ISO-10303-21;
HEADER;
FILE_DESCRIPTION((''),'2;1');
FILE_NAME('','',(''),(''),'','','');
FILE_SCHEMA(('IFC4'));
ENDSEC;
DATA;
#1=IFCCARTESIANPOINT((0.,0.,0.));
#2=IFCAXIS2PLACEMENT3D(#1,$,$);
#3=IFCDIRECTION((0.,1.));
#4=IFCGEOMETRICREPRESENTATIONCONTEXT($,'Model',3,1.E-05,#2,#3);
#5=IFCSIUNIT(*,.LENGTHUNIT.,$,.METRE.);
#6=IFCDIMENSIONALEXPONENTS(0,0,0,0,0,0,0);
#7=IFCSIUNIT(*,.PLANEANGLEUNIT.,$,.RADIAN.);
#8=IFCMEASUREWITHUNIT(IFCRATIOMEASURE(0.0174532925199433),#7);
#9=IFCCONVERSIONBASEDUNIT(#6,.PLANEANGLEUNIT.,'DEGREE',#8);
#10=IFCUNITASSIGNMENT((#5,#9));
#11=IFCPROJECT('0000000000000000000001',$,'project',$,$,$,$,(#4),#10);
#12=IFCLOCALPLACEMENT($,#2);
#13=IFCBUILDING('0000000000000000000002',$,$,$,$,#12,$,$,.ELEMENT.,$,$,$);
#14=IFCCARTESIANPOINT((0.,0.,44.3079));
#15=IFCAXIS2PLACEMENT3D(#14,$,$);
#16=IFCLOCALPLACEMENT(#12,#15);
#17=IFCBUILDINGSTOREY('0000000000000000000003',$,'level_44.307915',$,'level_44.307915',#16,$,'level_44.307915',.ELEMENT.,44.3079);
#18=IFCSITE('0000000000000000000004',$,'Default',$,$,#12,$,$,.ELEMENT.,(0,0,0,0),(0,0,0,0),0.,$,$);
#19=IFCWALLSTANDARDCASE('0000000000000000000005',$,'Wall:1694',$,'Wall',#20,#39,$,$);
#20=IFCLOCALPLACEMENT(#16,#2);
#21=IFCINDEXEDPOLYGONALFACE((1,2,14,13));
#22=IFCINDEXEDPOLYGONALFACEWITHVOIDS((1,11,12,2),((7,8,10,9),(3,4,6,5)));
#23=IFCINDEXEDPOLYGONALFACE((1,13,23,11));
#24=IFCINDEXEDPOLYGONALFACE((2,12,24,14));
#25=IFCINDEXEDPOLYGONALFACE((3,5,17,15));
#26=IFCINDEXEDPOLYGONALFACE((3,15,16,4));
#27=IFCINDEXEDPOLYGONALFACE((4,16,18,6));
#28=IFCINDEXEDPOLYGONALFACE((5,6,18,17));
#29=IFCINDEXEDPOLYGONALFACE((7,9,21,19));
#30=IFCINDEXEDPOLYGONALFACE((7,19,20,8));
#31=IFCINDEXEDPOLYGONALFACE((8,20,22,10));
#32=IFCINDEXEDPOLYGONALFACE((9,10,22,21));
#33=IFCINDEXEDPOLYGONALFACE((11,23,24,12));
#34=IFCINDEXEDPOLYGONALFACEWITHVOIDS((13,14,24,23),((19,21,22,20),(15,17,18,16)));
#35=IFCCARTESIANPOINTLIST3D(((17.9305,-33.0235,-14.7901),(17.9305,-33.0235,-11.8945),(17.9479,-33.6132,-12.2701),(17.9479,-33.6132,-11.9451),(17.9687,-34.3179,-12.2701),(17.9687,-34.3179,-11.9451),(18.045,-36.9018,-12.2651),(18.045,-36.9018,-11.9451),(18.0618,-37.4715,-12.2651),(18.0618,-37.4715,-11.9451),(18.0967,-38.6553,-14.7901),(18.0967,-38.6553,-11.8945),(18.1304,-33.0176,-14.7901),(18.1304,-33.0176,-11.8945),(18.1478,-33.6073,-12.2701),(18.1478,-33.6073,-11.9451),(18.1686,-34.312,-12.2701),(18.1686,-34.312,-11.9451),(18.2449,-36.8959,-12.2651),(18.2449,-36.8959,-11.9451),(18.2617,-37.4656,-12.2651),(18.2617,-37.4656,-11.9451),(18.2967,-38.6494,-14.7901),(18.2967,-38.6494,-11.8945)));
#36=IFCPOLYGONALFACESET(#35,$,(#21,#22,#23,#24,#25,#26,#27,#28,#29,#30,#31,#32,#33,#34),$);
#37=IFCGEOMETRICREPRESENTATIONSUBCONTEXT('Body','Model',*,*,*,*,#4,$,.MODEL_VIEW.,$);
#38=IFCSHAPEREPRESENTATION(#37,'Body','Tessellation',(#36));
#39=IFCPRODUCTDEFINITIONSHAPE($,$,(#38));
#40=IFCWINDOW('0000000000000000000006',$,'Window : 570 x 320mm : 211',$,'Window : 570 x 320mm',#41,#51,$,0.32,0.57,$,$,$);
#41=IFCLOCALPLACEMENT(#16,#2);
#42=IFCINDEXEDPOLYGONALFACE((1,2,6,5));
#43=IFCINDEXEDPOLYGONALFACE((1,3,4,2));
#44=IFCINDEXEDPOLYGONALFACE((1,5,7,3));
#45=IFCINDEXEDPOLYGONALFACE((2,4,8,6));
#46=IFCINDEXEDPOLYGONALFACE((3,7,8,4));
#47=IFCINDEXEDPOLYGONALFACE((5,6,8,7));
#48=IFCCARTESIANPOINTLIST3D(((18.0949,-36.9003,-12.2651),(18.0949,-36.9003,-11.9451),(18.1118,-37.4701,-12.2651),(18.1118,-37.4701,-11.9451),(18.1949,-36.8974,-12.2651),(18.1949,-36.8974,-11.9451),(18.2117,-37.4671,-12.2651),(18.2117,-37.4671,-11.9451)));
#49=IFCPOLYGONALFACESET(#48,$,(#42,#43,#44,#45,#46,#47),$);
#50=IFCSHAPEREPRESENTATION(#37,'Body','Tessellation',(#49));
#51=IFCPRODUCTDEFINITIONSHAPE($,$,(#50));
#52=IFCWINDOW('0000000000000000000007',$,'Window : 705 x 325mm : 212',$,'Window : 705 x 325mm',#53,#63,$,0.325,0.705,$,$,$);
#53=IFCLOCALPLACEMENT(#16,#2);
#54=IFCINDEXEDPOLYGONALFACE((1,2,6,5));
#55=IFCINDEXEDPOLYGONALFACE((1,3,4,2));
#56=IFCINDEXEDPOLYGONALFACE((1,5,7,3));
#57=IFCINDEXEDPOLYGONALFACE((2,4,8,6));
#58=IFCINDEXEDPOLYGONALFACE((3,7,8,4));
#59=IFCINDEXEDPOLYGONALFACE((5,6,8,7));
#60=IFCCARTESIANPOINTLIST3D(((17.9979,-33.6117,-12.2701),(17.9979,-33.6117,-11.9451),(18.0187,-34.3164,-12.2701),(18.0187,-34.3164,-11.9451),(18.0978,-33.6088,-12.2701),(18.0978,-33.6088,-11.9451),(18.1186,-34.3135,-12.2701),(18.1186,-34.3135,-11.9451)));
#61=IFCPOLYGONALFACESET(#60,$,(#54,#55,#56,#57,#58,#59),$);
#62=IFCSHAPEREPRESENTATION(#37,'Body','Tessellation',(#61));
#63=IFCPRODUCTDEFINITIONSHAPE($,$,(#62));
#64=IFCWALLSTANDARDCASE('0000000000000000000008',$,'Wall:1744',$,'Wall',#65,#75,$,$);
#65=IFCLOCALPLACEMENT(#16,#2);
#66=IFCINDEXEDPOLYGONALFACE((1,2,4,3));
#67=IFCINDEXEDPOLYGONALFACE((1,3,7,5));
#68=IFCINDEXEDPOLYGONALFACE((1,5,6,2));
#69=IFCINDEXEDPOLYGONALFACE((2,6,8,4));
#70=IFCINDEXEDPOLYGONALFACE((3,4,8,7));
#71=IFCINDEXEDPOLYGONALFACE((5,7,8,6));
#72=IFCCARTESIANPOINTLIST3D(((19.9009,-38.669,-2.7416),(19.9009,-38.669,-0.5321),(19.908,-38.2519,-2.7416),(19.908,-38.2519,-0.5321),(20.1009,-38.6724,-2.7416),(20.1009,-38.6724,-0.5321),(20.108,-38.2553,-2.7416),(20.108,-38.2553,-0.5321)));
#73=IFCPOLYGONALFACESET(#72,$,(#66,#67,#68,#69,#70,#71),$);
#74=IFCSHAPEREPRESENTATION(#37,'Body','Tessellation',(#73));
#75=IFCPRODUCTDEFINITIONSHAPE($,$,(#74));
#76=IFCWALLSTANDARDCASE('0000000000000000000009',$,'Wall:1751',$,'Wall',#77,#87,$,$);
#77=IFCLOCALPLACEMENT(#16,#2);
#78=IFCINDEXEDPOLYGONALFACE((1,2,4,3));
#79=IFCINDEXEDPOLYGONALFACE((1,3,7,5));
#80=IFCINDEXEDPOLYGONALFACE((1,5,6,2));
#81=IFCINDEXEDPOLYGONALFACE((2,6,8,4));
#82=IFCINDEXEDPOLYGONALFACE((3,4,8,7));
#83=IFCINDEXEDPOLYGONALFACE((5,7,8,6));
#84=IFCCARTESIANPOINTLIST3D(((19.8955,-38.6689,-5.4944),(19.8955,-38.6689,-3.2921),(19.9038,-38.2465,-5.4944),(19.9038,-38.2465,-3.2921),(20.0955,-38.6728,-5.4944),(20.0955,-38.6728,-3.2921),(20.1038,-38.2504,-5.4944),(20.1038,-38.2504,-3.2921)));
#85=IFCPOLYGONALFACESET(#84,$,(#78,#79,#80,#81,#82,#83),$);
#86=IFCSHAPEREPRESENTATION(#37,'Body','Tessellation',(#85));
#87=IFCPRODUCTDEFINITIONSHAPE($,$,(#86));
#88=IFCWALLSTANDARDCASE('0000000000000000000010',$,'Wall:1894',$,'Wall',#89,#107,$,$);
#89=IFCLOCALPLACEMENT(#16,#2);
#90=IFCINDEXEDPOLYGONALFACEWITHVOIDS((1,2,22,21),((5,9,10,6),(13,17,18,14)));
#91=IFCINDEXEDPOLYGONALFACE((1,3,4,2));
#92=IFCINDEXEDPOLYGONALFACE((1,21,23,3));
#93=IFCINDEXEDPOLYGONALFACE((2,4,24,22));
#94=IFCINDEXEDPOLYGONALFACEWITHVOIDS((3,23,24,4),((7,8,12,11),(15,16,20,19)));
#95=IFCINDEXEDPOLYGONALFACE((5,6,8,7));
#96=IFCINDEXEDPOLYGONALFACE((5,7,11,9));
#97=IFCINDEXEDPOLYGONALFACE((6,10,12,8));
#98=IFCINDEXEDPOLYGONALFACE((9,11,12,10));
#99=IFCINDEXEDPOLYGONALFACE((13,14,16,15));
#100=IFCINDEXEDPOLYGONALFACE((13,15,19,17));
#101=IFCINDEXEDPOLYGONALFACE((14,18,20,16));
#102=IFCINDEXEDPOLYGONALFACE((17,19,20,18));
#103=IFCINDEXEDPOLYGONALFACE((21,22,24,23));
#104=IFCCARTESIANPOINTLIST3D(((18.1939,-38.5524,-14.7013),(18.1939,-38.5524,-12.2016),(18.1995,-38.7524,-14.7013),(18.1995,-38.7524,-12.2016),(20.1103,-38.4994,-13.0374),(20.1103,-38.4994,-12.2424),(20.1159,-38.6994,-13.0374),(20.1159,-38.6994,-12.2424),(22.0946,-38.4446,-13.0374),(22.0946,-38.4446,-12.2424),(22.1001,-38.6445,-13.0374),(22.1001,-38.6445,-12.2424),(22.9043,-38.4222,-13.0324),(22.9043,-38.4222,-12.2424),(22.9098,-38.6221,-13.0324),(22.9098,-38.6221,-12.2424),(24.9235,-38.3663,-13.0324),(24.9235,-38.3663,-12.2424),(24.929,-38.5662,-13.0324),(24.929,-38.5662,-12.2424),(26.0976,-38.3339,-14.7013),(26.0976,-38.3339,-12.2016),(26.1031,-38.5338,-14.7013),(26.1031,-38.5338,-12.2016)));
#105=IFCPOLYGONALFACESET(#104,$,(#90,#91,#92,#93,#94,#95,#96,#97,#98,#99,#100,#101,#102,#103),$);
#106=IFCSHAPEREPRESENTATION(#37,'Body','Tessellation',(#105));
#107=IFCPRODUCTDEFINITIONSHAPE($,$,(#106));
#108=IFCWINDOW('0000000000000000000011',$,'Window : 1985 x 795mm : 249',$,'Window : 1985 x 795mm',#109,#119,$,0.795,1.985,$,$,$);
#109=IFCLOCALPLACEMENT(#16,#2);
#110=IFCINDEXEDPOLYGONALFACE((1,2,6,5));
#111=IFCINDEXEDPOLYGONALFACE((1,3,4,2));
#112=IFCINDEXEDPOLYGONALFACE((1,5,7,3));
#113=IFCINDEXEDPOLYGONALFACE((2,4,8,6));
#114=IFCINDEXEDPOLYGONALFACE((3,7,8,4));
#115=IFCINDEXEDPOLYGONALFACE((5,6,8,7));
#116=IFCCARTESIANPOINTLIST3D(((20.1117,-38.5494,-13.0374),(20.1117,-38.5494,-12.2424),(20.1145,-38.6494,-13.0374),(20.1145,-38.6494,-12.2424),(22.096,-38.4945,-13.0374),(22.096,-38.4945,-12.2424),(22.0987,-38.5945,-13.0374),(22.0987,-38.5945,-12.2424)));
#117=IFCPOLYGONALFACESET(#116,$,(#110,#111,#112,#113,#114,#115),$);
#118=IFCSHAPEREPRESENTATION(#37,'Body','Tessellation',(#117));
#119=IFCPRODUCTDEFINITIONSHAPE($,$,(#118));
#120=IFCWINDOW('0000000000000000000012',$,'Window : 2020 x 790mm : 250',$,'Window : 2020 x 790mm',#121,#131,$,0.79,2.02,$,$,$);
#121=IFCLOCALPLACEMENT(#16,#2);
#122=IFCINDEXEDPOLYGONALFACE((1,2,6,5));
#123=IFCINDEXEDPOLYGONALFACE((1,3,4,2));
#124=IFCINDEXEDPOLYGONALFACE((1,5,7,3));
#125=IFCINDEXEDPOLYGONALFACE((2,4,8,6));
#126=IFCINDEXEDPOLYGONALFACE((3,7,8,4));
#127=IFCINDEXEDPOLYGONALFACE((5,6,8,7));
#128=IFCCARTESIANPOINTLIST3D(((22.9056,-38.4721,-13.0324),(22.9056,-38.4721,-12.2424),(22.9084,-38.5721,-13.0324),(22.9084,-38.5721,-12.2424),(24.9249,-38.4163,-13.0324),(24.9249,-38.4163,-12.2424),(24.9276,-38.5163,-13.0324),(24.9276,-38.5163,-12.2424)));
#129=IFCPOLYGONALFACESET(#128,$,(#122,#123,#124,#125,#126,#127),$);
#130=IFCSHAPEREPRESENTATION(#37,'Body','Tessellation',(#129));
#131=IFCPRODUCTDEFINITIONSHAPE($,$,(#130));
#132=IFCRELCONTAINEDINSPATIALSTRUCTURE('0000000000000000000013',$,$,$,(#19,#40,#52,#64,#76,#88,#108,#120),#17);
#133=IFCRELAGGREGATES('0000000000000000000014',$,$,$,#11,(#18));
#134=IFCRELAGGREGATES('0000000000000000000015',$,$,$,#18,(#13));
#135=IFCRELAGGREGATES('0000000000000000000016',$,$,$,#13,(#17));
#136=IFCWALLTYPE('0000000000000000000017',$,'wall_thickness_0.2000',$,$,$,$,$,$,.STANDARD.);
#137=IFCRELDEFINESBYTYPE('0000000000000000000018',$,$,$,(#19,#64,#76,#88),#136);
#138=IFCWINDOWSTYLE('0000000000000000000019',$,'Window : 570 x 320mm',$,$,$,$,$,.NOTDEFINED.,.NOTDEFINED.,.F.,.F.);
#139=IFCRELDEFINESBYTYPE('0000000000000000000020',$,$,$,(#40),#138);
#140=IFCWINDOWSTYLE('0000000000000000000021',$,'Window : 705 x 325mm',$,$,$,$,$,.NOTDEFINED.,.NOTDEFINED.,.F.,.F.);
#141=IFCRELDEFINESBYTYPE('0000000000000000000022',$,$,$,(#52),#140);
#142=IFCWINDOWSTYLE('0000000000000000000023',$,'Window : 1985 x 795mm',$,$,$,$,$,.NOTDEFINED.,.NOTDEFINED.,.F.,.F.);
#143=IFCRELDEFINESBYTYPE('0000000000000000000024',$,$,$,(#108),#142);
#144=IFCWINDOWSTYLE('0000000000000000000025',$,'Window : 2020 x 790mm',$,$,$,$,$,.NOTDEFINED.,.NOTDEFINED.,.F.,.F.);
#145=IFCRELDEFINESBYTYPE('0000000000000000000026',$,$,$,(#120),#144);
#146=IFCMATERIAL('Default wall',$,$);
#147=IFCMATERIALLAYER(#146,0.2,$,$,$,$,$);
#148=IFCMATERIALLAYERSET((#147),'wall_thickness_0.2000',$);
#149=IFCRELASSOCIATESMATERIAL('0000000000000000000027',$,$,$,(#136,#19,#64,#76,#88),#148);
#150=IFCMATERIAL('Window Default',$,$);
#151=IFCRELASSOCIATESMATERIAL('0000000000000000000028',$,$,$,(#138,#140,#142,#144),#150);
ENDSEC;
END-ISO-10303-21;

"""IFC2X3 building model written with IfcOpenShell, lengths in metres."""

from ifc_helpers import new_model, entity, si_unit, converted_unit, direction, frame, frame_2d, origin, origin_2d_with_axis, place, context, subcontext, project, spatial, polyline, rectangle, outline, extrude, source, transform, mapped, material, layer, layer_set, layer_usage, type_object, type_shapes, element, fill, save


model = new_model("IFC2X3")

# Units and contexts
model_context = context("Model", 3, precision=1e-05, world=origin(), true_north=direction((0.0, 1.0)))
body_context = subcontext(model_context, "Body", "Model", "MODEL_VIEW")
ifc_project = project(units=[si_unit("LENGTHUNIT", "METRE"), converted_unit("PLANEANGLEUNIT", "DEGREE", entity("IfcRatioMeasure", 0.0174532925199433), si_unit("PLANEANGLEUNIT", "RADIAN"), dimensions=[0, 0, 0, 0, 0, 0, 0])], contexts=[model_context])

# Site, building, storey
placement_1 = place(None, origin())
site = spatial("IfcSite", under=ifc_project, at=placement_1, Name="Default", CompositionType="ELEMENT", RefLatitude=(0, 0, 0, 0), RefLongitude=(0, 0, 0, 0), RefElevation=0.0)
building = spatial("IfcBuilding", under=site, at=placement_1, CompositionType="ELEMENT")
storey_placement = place(placement_1, frame((0.0, 0.0, 44.3079)))
storey = spatial("IfcBuildingStorey", under=building, at=storey_placement, Name="level_44.307915", ObjectType="level_44.307915", LongName="level_44.307915", CompositionType="ELEMENT", Elevation=44.3079)

# Shared definitions
ifc_material_1 = material(Name="Default wall")
ifc_layer = layer(ifc_material_1, 0.2)
ifc_layer_set = layer_set([ifc_layer], Name="wall_thickness_0.2000")
ifc_layer_usage = layer_usage(ifc_layer_set, "AXIS2", "POSITIVE", -0.1)
wall_type = type_object("IfcWallType", Name="wall_thickness_0.2000", PredefinedType="STANDARD", material=ifc_layer_set)

# Wall, openings, windows
placement_2 = place(placement_1, frame((0.0, 0.0, 29.5178)))
wall_1_placement = place(placement_2, frame((18.1967, -38.6524, 0.0), z_axis=(0.0, 0.0, 1.0), x_axis=(-0.029511, 0.999564, 0.0)))
wall_1 = element("IfcWallStandardCase", 1, at=wall_1_placement, inside=storey, type_object=wall_type, material=ifc_layer_usage, Name="Wall:1694", ObjectType="Wall", context=body_context, shape_type="SweptSolid", body=[
    extrude(outline(polyline([(5.6343, -0.1), (5.6343, 0.1), (0.0, 0.1), (0.0, -0.1), (5.6343, -0.1)])), origin(), (0.0, 0.0, 1.0), 2.8956),
])
opening_1_placement = place(wall_1_placement, frame((1.1843, -0.1, 2.525)))
opening_1 = element("IfcOpeningElement", 2, at=opening_1_placement, cuts=wall_1, ObjectType="Opening", context=body_context, shape_type="SweptSolid", body=[
    extrude(rectangle(XDim=0.57, YDim=0.32, at=frame_2d((0.16, 0.285), x_axis=(0.0, 1.0))), frame((0.0, 0.0, 0.0), z_axis=(0.0, 1.0, 0.0), x_axis=(0.0, 0.0, 1.0)), (0.0, 0.0, 1.0), 0.2),
])
opening_2_placement = place(wall_1_placement, frame((4.3393, -0.1, 2.52)))
opening_2 = element("IfcOpeningElement", 3, at=opening_2_placement, cuts=wall_1, ObjectType="Opening", context=body_context, shape_type="SweptSolid", body=[
    extrude(rectangle(XDim=0.705, YDim=0.325, at=frame_2d((0.1625, 0.3525), x_axis=(0.0, 1.0))), frame((0.0, 0.0, 0.0), z_axis=(0.0, 1.0, 0.0), x_axis=(0.0, 0.0, 1.0)), (0.0, 0.0, 1.0), 0.2),
])
ifc_material_2 = material(Name="Window Default")
window_style_1 = type_object("IfcWindowStyle", Name="Window : 570 x 320mm", ConstructionType="NOTDEFINED", OperationType="NOTDEFINED", ParameterTakesPrecedence=False, Sizeable=False, material=ifc_material_2)
shared_shape_1 = source(origin(), body_context, "Body", "SweptSolid", [
    extrude(rectangle(XDim=0.1, YDim=0.57, at=origin_2d_with_axis()), frame((0.285, 0.1, 0.0), z_axis=(0.0, 0.0, 1.0), x_axis=(0.0, 1.0, 0.0)), (0.0, 0.0, 1.0), 0.32),
])
type_shapes(window_style_1, [shared_shape_1])
window_1_placement = place(opening_1_placement, origin())
window_1 = element("IfcWindow", 4, at=window_1_placement, inside=storey, type_object=window_style_1, Name="Window : 570 x 320mm : 211", ObjectType="Window : 570 x 320mm", OverallHeight=0.32, OverallWidth=0.57, context=body_context, shape_type="MappedRepresentation", body=[
    mapped(shared_shape_1, transform((0.0, 0.0, 0.0), scale=1.0)),
])
fill(opening_1, window_1)
window_style_2 = type_object("IfcWindowStyle", Name="Window : 705 x 325mm", ConstructionType="NOTDEFINED", OperationType="NOTDEFINED", ParameterTakesPrecedence=False, Sizeable=False, material=ifc_material_2)
shared_shape_2 = source(origin(), body_context, "Body", "SweptSolid", [
    extrude(rectangle(XDim=0.1, YDim=0.705, at=origin_2d_with_axis()), frame((0.3525, 0.1, 0.0), z_axis=(0.0, 0.0, 1.0), x_axis=(0.0, 1.0, 0.0)), (0.0, 0.0, 1.0), 0.325),
])
type_shapes(window_style_2, [shared_shape_2])
window_2_placement = place(opening_2_placement, origin())
window_2 = element("IfcWindow", 5, at=window_2_placement, inside=storey, type_object=window_style_2, Name="Window : 705 x 325mm : 212", ObjectType="Window : 705 x 325mm", OverallHeight=0.325, OverallWidth=0.705, context=body_context, shape_type="MappedRepresentation", body=[
    mapped(shared_shape_2, transform((0.0, 0.0, 0.0), scale=1.0)),
])
fill(opening_2, window_2)

# Walls
placement_3 = place(placement_1, frame((0.0, 0.0, 41.5663)))
wall_2_placement = place(placement_3, frame((20.0009, -38.6707, 0.0), z_axis=(0.0, 0.0, 1.0), x_axis=(0.01709, 0.999854, 0.0)))
element("IfcWallStandardCase", 6, at=wall_2_placement, inside=storey, type_object=wall_type, material=ifc_layer_usage, Name="Wall:1744", ObjectType="Wall", context=body_context, shape_type="SweptSolid", body=[
    extrude(outline(polyline([(0.4172, -0.1), (0.4172, 0.1), (0.0, 0.1), (0.0, -0.1), (0.4172, -0.1)])), origin(), (0.0, 0.0, 1.0), 2.2095),
])
placement_4 = place(placement_1, frame((0.0, 0.0, 38.8135)))
wall_3_placement = place(placement_4, frame((20.0038, -38.2484, 0.0), z_axis=(0.0, 0.0, 1.0), x_axis=(-0.019565, -0.999809, 0.0)))
element("IfcWallStandardCase", 7, at=wall_3_placement, inside=storey, type_object=wall_type, material=ifc_layer_usage, Name="Wall:1751", ObjectType="Wall", context=body_context, shape_type="SweptSolid", body=[
    extrude(outline(polyline([(0.4225, -0.1), (0.4225, 0.1), (0.0, 0.1), (0.0, -0.1), (0.4225, -0.1)])), origin(), (0.0, 0.0, 1.0), 2.2023),
])

# Wall, openings, windows
placement_5 = place(placement_1, frame((0.0, 0.0, 29.6066)))
wall_4_placement = place(placement_5, frame((18.1967, -38.6524, 0.0), z_axis=(0.0, 0.0, 1.0), x_axis=(0.999618, 0.027644, 0.0)))
wall_4 = element("IfcWallStandardCase", 8, at=wall_4_placement, inside=storey, type_object=wall_type, material=ifc_layer_usage, Name="Wall:1894", ObjectType="Wall", context=body_context, shape_type="SweptSolid", body=[
    extrude(outline(polyline([(7.9066, -0.1), (7.9066, 0.1), (0.0, 0.1), (0.0, -0.1), (7.9066, -0.1)])), origin(), (0.0, 0.0, 1.0), 2.4996),
])
opening_3_placement = place(wall_4_placement, frame((1.9171, -0.1, 1.6639)))
opening_3 = element("IfcOpeningElement", 9, at=opening_3_placement, cuts=wall_4, ObjectType="Opening", context=body_context, shape_type="SweptSolid", body=[
    extrude(rectangle(XDim=1.985, YDim=0.795, at=frame_2d((0.3975, 0.9925), x_axis=(0.0, 1.0))), frame((0.0, 0.0, 0.0), z_axis=(0.0, 1.0, 0.0), x_axis=(0.0, 0.0, 1.0)), (0.0, 0.0, 1.0), 0.2),
])
opening_4_placement = place(wall_4_placement, frame((4.7121, -0.1, 1.6689)))
opening_4 = element("IfcOpeningElement", 10, at=opening_4_placement, cuts=wall_4, ObjectType="Opening", context=body_context, shape_type="SweptSolid", body=[
    extrude(rectangle(XDim=2.02, YDim=0.79, at=frame_2d((0.395, 1.01), x_axis=(0.0, 1.0))), frame((0.0, 0.0, 0.0), z_axis=(0.0, 1.0, 0.0), x_axis=(0.0, 0.0, 1.0)), (0.0, 0.0, 1.0), 0.2),
])
window_style_3 = type_object("IfcWindowStyle", Name="Window : 1985 x 795mm", ConstructionType="NOTDEFINED", OperationType="NOTDEFINED", ParameterTakesPrecedence=False, Sizeable=False, material=ifc_material_2)
shared_shape_3 = source(origin(), body_context, "Body", "SweptSolid", [
    extrude(rectangle(XDim=0.1, YDim=1.985, at=origin_2d_with_axis()), frame((0.9925, 0.1, 0.0), z_axis=(0.0, 0.0, 1.0), x_axis=(0.0, 1.0, 0.0)), (0.0, 0.0, 1.0), 0.795),
])
type_shapes(window_style_3, [shared_shape_3])
window_3_placement = place(opening_3_placement, origin())
window_3 = element("IfcWindow", 11, at=window_3_placement, inside=storey, type_object=window_style_3, Name="Window : 1985 x 795mm : 249", ObjectType="Window : 1985 x 795mm", OverallHeight=0.795, OverallWidth=1.985, context=body_context, shape_type="MappedRepresentation", body=[
    mapped(shared_shape_3, transform((0.0, 0.0, 0.0), scale=1.0)),
])
fill(opening_3, window_3)
window_style_4 = type_object("IfcWindowStyle", Name="Window : 2020 x 790mm", ConstructionType="NOTDEFINED", OperationType="NOTDEFINED", ParameterTakesPrecedence=False, Sizeable=False, material=ifc_material_2)
shared_shape_4 = source(origin(), body_context, "Body", "SweptSolid", [
    extrude(rectangle(XDim=0.1, YDim=2.02, at=origin_2d_with_axis()), frame((1.01, 0.1, 0.0), z_axis=(0.0, 0.0, 1.0), x_axis=(0.0, 1.0, 0.0)), (0.0, 0.0, 1.0), 0.79),
])
type_shapes(window_style_4, [shared_shape_4])
window_4_placement = place(opening_4_placement, origin())
window_4 = element("IfcWindow", 12, at=window_4_placement, inside=storey, type_object=window_style_4, Name="Window : 2020 x 790mm : 250", ObjectType="Window : 2020 x 790mm", OverallHeight=0.79, OverallWidth=2.02, context=body_context, shape_type="MappedRepresentation", body=[
    mapped(shared_shape_4, transform((0.0, 0.0, 0.0), scale=1.0)),
])
fill(opening_4, window_4)

save(model, "model.ifc")
